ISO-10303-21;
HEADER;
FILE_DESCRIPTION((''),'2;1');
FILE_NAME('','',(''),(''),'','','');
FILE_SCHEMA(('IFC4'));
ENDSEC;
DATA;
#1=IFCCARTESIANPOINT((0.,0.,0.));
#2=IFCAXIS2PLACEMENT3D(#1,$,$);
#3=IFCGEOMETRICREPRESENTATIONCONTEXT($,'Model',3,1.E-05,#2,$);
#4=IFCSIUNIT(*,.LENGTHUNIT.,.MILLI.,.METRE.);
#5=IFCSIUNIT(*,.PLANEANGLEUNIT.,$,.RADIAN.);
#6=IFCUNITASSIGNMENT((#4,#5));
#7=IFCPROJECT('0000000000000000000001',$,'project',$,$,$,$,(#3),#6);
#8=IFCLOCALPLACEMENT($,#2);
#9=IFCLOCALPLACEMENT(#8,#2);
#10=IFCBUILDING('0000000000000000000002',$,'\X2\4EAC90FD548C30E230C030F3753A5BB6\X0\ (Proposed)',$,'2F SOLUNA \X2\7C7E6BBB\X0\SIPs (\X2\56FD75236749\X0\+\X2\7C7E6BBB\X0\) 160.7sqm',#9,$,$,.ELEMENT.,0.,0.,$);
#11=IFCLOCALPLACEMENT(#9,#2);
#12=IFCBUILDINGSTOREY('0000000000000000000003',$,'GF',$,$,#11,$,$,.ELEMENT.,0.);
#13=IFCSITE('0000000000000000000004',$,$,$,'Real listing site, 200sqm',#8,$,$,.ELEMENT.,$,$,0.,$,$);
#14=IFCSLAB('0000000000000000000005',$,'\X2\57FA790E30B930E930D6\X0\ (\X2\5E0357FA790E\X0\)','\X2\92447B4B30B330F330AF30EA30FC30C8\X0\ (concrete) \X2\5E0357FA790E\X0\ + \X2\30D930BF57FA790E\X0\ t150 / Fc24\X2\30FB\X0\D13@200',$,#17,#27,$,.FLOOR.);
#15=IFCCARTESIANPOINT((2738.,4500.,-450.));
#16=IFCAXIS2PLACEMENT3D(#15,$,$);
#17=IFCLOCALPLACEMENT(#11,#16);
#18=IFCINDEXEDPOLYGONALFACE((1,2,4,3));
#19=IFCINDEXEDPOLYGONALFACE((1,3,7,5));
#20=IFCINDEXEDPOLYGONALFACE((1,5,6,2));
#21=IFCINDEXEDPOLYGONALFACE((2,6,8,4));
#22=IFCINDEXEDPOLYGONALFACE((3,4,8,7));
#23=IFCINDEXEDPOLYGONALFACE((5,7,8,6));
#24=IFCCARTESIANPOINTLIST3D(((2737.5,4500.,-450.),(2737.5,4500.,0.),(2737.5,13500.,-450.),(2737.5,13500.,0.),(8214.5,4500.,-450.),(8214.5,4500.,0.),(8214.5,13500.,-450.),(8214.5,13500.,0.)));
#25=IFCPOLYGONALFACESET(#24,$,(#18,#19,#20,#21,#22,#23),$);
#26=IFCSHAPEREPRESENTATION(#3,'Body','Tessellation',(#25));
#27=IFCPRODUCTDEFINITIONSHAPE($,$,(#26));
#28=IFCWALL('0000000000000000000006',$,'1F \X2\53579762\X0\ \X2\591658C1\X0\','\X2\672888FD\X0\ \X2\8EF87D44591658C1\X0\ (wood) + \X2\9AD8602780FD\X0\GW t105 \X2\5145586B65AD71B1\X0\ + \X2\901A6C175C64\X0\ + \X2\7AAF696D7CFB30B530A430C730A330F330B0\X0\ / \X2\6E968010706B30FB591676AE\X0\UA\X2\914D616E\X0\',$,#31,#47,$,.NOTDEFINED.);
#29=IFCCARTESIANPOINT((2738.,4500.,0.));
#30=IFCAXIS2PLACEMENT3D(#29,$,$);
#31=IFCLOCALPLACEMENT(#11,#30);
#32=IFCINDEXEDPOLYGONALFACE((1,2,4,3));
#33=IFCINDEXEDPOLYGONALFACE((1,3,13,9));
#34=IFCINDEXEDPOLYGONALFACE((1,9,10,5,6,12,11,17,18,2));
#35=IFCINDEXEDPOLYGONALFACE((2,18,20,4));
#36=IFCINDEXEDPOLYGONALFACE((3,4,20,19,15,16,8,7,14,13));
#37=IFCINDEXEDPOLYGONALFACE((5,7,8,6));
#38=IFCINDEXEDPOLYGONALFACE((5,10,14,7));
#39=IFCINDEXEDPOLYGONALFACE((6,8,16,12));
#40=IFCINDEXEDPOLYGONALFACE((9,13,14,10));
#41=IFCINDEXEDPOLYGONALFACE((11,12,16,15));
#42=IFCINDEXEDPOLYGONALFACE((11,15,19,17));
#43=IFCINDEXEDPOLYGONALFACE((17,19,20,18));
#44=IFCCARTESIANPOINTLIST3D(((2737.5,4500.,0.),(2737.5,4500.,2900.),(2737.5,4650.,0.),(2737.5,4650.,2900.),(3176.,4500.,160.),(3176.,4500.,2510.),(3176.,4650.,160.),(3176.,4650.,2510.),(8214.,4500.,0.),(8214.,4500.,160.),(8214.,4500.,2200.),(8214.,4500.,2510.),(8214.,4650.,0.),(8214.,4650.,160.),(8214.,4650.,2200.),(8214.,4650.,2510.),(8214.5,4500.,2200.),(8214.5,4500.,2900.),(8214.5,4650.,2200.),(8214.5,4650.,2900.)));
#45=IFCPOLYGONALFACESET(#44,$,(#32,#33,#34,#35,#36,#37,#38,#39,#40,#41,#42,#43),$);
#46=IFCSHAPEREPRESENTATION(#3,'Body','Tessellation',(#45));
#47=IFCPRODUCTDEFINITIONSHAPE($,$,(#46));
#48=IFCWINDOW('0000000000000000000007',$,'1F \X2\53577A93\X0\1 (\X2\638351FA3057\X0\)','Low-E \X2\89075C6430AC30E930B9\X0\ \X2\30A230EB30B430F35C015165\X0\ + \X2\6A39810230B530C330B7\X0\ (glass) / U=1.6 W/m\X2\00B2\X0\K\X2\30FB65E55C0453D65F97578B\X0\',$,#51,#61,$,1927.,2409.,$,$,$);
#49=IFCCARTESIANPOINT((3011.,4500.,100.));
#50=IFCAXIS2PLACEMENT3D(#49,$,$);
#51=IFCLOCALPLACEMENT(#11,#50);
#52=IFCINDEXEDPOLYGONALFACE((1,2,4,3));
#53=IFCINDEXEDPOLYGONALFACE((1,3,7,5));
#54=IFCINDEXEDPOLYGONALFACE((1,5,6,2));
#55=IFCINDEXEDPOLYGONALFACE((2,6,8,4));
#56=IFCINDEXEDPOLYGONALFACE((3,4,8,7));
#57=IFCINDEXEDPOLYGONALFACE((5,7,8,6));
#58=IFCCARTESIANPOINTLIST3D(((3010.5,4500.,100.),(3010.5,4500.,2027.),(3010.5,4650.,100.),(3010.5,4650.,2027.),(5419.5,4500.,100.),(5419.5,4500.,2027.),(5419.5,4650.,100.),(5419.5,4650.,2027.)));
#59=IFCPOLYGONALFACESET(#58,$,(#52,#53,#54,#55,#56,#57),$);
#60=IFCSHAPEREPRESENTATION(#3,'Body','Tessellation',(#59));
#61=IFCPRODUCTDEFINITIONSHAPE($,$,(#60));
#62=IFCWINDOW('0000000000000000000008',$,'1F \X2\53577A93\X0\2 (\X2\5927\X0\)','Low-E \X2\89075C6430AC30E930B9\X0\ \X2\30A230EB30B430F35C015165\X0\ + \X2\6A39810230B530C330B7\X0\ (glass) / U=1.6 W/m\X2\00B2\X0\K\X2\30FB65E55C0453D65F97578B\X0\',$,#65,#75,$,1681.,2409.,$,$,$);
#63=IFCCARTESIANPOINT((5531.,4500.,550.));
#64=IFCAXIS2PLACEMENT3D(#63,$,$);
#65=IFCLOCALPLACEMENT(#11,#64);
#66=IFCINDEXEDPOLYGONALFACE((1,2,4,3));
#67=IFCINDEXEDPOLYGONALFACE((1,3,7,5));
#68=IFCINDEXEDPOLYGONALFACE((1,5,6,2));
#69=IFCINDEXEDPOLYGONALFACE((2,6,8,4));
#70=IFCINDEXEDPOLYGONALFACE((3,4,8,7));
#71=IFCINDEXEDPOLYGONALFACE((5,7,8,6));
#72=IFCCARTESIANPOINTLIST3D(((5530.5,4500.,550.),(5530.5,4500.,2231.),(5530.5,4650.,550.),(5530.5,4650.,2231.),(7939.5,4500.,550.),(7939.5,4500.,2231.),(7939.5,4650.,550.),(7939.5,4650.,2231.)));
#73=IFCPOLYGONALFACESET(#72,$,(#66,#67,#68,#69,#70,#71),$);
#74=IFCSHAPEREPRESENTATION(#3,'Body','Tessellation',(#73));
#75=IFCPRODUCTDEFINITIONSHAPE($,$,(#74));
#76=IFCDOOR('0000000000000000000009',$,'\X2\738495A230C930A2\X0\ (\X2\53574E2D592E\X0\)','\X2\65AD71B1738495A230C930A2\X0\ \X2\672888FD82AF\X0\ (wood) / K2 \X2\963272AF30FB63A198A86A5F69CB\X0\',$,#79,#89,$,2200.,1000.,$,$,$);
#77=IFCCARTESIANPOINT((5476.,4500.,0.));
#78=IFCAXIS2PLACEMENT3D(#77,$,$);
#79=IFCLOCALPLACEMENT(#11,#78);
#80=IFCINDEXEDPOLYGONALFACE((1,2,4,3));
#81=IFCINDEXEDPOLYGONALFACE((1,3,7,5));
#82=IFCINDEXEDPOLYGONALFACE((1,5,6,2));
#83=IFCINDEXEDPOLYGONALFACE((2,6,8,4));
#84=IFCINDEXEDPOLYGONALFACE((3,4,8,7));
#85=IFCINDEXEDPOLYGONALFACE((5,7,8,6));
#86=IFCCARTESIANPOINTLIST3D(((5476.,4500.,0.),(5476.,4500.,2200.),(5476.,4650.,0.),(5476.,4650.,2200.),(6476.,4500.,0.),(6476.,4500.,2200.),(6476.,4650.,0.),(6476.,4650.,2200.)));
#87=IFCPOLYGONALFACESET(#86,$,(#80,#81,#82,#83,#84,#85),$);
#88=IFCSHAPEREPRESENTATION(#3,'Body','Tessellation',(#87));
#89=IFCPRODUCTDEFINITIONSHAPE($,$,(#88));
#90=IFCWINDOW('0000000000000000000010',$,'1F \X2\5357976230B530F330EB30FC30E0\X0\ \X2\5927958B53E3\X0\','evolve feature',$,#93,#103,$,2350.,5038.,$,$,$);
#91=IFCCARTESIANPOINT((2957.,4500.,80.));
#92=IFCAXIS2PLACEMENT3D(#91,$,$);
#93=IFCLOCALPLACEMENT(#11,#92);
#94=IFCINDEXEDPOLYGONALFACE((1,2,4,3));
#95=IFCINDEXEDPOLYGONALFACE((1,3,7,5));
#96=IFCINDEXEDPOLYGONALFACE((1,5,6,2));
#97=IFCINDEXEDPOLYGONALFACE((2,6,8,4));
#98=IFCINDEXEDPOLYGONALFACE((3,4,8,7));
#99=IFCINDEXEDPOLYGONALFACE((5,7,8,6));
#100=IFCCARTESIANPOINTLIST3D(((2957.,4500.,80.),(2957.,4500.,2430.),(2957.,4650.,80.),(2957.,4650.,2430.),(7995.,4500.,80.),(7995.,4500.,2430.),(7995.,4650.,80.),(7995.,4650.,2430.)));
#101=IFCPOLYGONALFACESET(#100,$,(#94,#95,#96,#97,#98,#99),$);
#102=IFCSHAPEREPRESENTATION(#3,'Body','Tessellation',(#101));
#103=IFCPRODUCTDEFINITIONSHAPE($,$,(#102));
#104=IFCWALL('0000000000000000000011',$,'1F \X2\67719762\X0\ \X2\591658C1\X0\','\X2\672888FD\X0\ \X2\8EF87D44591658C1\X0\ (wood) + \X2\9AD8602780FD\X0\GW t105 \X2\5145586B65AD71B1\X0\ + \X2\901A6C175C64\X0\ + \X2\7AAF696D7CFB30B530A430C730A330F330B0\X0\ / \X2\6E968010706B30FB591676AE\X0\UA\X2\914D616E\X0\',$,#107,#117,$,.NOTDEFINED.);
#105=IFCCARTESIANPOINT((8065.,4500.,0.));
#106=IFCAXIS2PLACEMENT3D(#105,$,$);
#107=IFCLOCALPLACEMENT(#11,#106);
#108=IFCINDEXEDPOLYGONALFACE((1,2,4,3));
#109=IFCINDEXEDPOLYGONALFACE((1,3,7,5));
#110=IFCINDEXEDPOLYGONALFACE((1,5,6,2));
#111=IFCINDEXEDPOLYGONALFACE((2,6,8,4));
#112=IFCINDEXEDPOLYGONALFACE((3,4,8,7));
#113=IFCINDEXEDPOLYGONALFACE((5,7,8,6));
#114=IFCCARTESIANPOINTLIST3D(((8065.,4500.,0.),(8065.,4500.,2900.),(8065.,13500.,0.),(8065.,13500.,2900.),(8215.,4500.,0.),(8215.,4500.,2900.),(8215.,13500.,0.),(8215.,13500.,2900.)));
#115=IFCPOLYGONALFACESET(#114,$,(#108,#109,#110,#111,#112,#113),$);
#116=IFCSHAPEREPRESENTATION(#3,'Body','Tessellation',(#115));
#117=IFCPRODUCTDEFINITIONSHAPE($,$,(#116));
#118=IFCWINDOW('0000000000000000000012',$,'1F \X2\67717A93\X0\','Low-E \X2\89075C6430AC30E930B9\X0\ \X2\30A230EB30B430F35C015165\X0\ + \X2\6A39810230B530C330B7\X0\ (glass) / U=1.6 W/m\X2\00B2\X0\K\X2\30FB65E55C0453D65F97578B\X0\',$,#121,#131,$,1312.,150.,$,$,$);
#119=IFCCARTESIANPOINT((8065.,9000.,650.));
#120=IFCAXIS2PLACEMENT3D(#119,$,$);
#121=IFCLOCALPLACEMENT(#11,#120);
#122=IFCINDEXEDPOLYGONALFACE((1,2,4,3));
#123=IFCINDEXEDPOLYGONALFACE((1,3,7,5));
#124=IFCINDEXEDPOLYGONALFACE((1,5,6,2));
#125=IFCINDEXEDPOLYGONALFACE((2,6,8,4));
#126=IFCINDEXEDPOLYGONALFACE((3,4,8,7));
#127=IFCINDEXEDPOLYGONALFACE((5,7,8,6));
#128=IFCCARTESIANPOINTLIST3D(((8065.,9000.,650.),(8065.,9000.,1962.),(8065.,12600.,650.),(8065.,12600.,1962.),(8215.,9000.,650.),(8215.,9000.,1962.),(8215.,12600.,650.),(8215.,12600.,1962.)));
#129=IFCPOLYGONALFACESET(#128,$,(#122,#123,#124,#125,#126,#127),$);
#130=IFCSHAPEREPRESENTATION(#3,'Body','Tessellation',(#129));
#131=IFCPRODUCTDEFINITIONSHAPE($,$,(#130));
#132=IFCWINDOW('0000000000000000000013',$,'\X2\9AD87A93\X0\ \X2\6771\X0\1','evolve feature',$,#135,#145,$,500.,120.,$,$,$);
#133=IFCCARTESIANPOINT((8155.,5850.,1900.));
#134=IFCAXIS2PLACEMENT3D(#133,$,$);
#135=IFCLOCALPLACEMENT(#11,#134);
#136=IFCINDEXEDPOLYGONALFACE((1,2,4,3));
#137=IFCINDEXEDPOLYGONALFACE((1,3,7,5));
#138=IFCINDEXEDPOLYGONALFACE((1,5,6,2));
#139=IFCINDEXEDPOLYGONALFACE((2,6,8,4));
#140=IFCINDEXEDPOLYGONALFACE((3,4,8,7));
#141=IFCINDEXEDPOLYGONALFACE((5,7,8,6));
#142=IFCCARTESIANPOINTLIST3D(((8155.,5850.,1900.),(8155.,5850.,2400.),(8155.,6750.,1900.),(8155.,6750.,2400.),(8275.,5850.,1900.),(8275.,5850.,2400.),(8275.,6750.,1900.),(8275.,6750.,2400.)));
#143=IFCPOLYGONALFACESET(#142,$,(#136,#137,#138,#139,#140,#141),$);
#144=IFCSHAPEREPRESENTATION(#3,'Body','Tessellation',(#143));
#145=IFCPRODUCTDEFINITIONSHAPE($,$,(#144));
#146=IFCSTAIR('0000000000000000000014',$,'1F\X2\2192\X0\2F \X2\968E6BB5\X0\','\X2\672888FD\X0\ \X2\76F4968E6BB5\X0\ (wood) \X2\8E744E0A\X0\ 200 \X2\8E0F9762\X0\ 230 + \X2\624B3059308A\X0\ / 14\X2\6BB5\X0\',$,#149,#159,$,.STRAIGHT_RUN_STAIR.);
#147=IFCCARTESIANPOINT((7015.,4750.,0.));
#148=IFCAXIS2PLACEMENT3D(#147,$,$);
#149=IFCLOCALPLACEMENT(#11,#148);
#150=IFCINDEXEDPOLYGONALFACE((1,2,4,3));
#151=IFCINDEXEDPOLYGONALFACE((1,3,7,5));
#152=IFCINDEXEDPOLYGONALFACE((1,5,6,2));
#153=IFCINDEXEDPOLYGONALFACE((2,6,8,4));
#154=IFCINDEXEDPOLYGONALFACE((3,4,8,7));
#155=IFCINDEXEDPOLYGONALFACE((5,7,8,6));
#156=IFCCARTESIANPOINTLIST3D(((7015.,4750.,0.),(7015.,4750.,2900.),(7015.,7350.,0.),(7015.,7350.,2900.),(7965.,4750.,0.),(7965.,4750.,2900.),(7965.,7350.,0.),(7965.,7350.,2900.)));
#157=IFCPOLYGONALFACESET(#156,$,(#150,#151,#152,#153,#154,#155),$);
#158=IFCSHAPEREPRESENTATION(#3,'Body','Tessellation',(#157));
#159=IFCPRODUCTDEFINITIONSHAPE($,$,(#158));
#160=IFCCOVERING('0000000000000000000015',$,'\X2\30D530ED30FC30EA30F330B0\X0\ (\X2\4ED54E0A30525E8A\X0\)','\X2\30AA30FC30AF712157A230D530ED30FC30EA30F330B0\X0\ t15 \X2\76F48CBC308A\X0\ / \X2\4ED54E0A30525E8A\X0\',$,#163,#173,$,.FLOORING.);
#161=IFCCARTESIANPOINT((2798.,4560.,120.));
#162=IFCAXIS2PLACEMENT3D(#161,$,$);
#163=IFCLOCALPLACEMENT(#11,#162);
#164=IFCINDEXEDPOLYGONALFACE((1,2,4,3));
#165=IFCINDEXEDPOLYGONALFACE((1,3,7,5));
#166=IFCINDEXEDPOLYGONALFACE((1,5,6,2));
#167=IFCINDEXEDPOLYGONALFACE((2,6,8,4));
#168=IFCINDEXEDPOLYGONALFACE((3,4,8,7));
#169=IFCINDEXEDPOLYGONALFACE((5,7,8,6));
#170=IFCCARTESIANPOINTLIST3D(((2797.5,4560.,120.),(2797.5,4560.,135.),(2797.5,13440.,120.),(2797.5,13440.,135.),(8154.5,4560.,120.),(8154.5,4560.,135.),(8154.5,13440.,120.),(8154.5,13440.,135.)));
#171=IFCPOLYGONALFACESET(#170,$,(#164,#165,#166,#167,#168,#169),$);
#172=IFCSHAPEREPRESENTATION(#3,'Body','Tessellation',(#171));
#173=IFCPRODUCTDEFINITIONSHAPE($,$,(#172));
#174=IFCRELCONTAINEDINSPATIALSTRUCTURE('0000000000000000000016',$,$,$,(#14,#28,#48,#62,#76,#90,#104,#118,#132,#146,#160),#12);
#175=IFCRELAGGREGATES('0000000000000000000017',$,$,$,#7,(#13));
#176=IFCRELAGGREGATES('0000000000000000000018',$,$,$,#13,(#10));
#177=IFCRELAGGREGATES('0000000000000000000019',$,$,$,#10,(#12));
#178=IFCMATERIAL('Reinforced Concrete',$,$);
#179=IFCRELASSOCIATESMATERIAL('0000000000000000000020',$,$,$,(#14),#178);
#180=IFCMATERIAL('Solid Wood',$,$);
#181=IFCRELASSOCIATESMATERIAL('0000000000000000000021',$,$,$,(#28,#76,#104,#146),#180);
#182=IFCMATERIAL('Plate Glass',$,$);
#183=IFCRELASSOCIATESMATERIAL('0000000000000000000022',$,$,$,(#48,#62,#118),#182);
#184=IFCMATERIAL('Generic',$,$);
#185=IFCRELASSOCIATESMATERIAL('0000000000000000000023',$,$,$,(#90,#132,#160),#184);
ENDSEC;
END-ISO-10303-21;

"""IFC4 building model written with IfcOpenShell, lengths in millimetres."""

from ifc_helpers import new_model, si_unit, frame, frame_2d, origin, place, context, project, spatial, rectangle, extrude, material, element, fill, save


model = new_model("IFC4")

# Units and contexts
model_context = context("Model", 3, precision=1e-05, world=origin())
ifc_project = project(units=[si_unit("LENGTHUNIT", "METRE", prefix="MILLI"), si_unit("PLANEANGLEUNIT", "RADIAN")], contexts=[model_context])

# Site, building, storey
site_placement = place(None, origin())
site = spatial("IfcSite", under=ifc_project, at=site_placement, ObjectType="Real listing site, 200sqm", CompositionType="ELEMENT", RefElevation=0.0)
building_placement = place(site_placement, origin())
building = spatial("IfcBuilding", under=site, at=building_placement, Name="京都和モダン町家 (Proposed)", ObjectType="2F SOLUNA 籾殻SIPs (国産杉+籾殻) 160.7sqm", CompositionType="ELEMENT", ElevationOfRefHeight=0.0, ElevationOfTerrain=0.0)
storey_placement = place(building_placement, origin())
storey = spatial("IfcBuildingStorey", under=building, at=storey_placement, Name="GF", CompositionType="ELEMENT", Elevation=0.0)

# Slab
ifc_material_1 = material(Name="Reinforced Concrete")
slab_1_placement = place(storey_placement, frame((2738.0, 4500.0, -450.0)))
element("IfcSlab", 1, at=slab_1_placement, inside=storey, material=ifc_material_1, Name="基礎スラブ (布基礎)", Description="鉄筋コンクリート (concrete) 布基礎 + ベタ基礎 t150 / Fc24・D13@200", PredefinedType="FLOOR", context=model_context, shape_type="SweptSolid", body=[
    extrude(rectangle(XDim=5477.0, YDim=9000.0, at=frame_2d((2738.0, 4500.0))), frame((2738.0, 4500.0, -450.0)), (0.0, 0.0, 1.0), 450.0),
])
ifc_material_2 = material(Name="Solid Wood")
ifc_material_3 = material(Name="Generic")

# Wall, openings, windows, door
wall_1_placement = place(storey_placement, frame((2738.0, 4500.0, 0.0)))
wall_1 = element("IfcWall", 2, at=wall_1_placement, inside=storey, material=ifc_material_2, Name="1F 南面 外壁", Description="木製 軸組外壁 (wood) + 高性能GW t105 充填断熱 + 通気層 + 窯業系サイディング / 準耐火・外皮UA配慮", PredefinedType="NOTDEFINED", context=model_context, shape_type="SweptSolid", body=[
    extrude(rectangle(XDim=5477.0, YDim=150.0, at=frame_2d((2738.0, 75.0))), frame((2738.0, 4500.0, 0.0)), (0.0, 0.0, 1.0), 2900.0),
])
opening_1_placement = place(storey_placement, frame((3011.0, 4500.0, 100.0)))
opening_1 = element("IfcOpeningElement", 3, at=opening_1_placement, cuts=wall_1, PredefinedType="NOTDEFINED", context=model_context, shape_type="SweptSolid", body=[
    extrude(rectangle(XDim=2409.0, YDim=150.0, at=frame_2d((1204.0, 75.0))), frame((3011.0, 4500.0, 100.0)), (0.0, 0.0, 1.0), 1927.0),
])
opening_2_placement = place(storey_placement, frame((5531.0, 4500.0, 550.0)))
opening_2 = element("IfcOpeningElement", 4, at=opening_2_placement, cuts=wall_1, PredefinedType="NOTDEFINED", context=model_context, shape_type="SweptSolid", body=[
    extrude(rectangle(XDim=2409.0, YDim=150.0, at=frame_2d((1204.0, 75.0))), frame((5531.0, 4500.0, 550.0)), (0.0, 0.0, 1.0), 1681.0),
])
opening_3_placement = place(storey_placement, frame((5476.0, 4500.0, 0.0)))
opening_3 = element("IfcOpeningElement", 5, at=opening_3_placement, cuts=wall_1, PredefinedType="NOTDEFINED", context=model_context, shape_type="SweptSolid", body=[
    extrude(rectangle(XDim=1000.0, YDim=150.0, at=frame_2d((500.0, 75.0))), frame((5476.0, 4500.0, 0.0)), (0.0, 0.0, 1.0), 2200.0),
])
opening_4_placement = place(storey_placement, frame((2957.0, 4500.0, 80.0)))
opening_4 = element("IfcOpeningElement", 6, at=opening_4_placement, cuts=wall_1, PredefinedType="NOTDEFINED", context=model_context, shape_type="SweptSolid", body=[
    extrude(rectangle(XDim=5038.0, YDim=150.0, at=frame_2d((2519.0, 75.0))), frame((2957.0, 4500.0, 80.0)), (0.0, 0.0, 1.0), 2350.0),
])
ifc_material_4 = material(Name="Plate Glass")
window_1_placement = place(storey_placement, frame((3011.0, 4500.0, 100.0)))
window_1 = element("IfcWindow", 7, at=window_1_placement, inside=storey, material=ifc_material_4, Name="1F 南窓1 (掃出し)", Description="Low-E 複層ガラス アルゴン封入 + 樹脂サッシ (glass) / U=1.6 W/m²K・日射取得型", OverallHeight=1927.0, OverallWidth=2409.0, context=model_context, shape_type="SweptSolid", body=[
    extrude(rectangle(XDim=2409.0, YDim=150.0, at=frame_2d((1204.0, 75.0))), frame((3011.0, 4500.0, 100.0)), (0.0, 0.0, 1.0), 1927.0),
])
fill(opening_1, window_1)
window_2_placement = place(storey_placement, frame((5531.0, 4500.0, 550.0)))
window_2 = element("IfcWindow", 8, at=window_2_placement, inside=storey, material=ifc_material_4, Name="1F 南窓2 (大)", Description="Low-E 複層ガラス アルゴン封入 + 樹脂サッシ (glass) / U=1.6 W/m²K・日射取得型", OverallHeight=1681.0, OverallWidth=2409.0, context=model_context, shape_type="SweptSolid", body=[
    extrude(rectangle(XDim=2409.0, YDim=150.0, at=frame_2d((1204.0, 75.0))), frame((5531.0, 4500.0, 550.0)), (0.0, 0.0, 1.0), 1681.0),
])
fill(opening_2, window_2)
door_placement = place(storey_placement, frame((5476.0, 4500.0, 0.0)))
door = element("IfcDoor", 9, at=door_placement, inside=storey, material=ifc_material_2, Name="玄関ドア (南中央)", Description="断熱玄関ドア 木製芯 (wood) / K2 防犯・採風機構", OverallHeight=2200.0, OverallWidth=1000.0, context=model_context, shape_type="SweptSolid", body=[
    extrude(rectangle(XDim=1000.0, YDim=150.0, at=frame_2d((500.0, 75.0))), frame((5476.0, 4500.0, 0.0)), (0.0, 0.0, 1.0), 2200.0),
])
fill(opening_3, door)
window_3_placement = place(storey_placement, frame((2957.0, 4500.0, 80.0)))
window_3 = element("IfcWindow", 10, at=window_3_placement, inside=storey, material=ifc_material_3, Name="1F 南面サンルーム 大開口", Description="evolve feature", OverallHeight=2350.0, OverallWidth=5038.0, context=model_context, shape_type="SweptSolid", body=[
    extrude(rectangle(XDim=5038.0, YDim=150.0, at=frame_2d((2519.0, 75.0))), frame((2957.0, 4500.0, 80.0)), (0.0, 0.0, 1.0), 2350.0),
])
fill(opening_4, window_3)

# Wall, openings, windows
wall_2_placement = place(storey_placement, frame((8065.0, 4500.0, 0.0)))
wall_2 = element("IfcWall", 11, at=wall_2_placement, inside=storey, material=ifc_material_2, Name="1F 東面 外壁", Description="木製 軸組外壁 (wood) + 高性能GW t105 充填断熱 + 通気層 + 窯業系サイディング / 準耐火・外皮UA配慮", PredefinedType="NOTDEFINED", context=model_context, shape_type="SweptSolid", body=[
    extrude(rectangle(XDim=150.0, YDim=9000.0, at=frame_2d((75.0, 4500.0))), frame((8065.0, 4500.0, 0.0)), (0.0, 0.0, 1.0), 2900.0),
])
opening_5_placement = place(storey_placement, frame((8065.0, 9000.0, 650.0)))
opening_5 = element("IfcOpeningElement", 12, at=opening_5_placement, cuts=wall_2, PredefinedType="NOTDEFINED", context=model_context, shape_type="SweptSolid", body=[
    extrude(rectangle(XDim=150.0, YDim=3600.0, at=frame_2d((75.0, 1800.0))), frame((8065.0, 9000.0, 650.0)), (0.0, 0.0, 1.0), 1312.0),
])
opening_6_placement = place(storey_placement, frame((8155.0, 5850.0, 1900.0)))
opening_6 = element("IfcOpeningElement", 13, at=opening_6_placement, cuts=wall_2, PredefinedType="NOTDEFINED", context=model_context, shape_type="SweptSolid", body=[
    extrude(rectangle(XDim=120.0, YDim=900.0, at=frame_2d((60.0, 450.0))), frame((8155.0, 5850.0, 1900.0)), (0.0, 0.0, 1.0), 500.0),
])
window_4_placement = place(storey_placement, frame((8065.0, 9000.0, 650.0)))
window_4 = element("IfcWindow", 14, at=window_4_placement, inside=storey, material=ifc_material_4, Name="1F 東窓", Description="Low-E 複層ガラス アルゴン封入 + 樹脂サッシ (glass) / U=1.6 W/m²K・日射取得型", OverallHeight=1312.0, OverallWidth=150.0, context=model_context, shape_type="SweptSolid", body=[
    extrude(rectangle(XDim=150.0, YDim=3600.0, at=frame_2d((75.0, 1800.0))), frame((8065.0, 9000.0, 650.0)), (0.0, 0.0, 1.0), 1312.0),
])
fill(opening_5, window_4)
window_5_placement = place(storey_placement, frame((8155.0, 5850.0, 1900.0)))
window_5 = element("IfcWindow", 15, at=window_5_placement, inside=storey, material=ifc_material_3, Name="高窓 東1", Description="evolve feature", OverallHeight=500.0, OverallWidth=120.0, context=model_context, shape_type="SweptSolid", body=[
    extrude(rectangle(XDim=120.0, YDim=900.0, at=frame_2d((60.0, 450.0))), frame((8155.0, 5850.0, 1900.0)), (0.0, 0.0, 1.0), 500.0),
])
fill(opening_6, window_5)

# Stair
stair_placement = place(storey_placement, frame((7015.0, 4750.0, 0.0)))
element("IfcStair", 16, at=stair_placement, inside=storey, material=ifc_material_2, Name="1F→2F 階段", Description="木製 直階段 (wood) 蹴上 200 踏面 230 + 手すり / 14段", PredefinedType="STRAIGHT_RUN_STAIR", context=model_context, shape_type="SweptSolid", body=[
    extrude(rectangle(XDim=950.0, YDim=2600.0, at=frame_2d((475.0, 1300.0))), frame((7015.0, 4750.0, 0.0)), (0.0, 0.0, 1.0), 2900.0),
])

# Covering
covering_placement = place(storey_placement, frame((2798.0, 4560.0, 120.0)))
element("IfcCovering", 17, at=covering_placement, inside=storey, material=ifc_material_3, Name="フローリング (仕上げ床)", Description="オーク無垢フローリング t15 直貼り / 仕上げ床", PredefinedType="FLOORING", context=model_context, shape_type="SweptSolid", body=[
    extrude(rectangle(XDim=5357.0, YDim=8880.0, at=frame_2d((2678.0, 4440.0))), frame((2798.0, 4560.0, 120.0)), (0.0, 0.0, 1.0), 15.0),
])

save(model, "model.ifc")
